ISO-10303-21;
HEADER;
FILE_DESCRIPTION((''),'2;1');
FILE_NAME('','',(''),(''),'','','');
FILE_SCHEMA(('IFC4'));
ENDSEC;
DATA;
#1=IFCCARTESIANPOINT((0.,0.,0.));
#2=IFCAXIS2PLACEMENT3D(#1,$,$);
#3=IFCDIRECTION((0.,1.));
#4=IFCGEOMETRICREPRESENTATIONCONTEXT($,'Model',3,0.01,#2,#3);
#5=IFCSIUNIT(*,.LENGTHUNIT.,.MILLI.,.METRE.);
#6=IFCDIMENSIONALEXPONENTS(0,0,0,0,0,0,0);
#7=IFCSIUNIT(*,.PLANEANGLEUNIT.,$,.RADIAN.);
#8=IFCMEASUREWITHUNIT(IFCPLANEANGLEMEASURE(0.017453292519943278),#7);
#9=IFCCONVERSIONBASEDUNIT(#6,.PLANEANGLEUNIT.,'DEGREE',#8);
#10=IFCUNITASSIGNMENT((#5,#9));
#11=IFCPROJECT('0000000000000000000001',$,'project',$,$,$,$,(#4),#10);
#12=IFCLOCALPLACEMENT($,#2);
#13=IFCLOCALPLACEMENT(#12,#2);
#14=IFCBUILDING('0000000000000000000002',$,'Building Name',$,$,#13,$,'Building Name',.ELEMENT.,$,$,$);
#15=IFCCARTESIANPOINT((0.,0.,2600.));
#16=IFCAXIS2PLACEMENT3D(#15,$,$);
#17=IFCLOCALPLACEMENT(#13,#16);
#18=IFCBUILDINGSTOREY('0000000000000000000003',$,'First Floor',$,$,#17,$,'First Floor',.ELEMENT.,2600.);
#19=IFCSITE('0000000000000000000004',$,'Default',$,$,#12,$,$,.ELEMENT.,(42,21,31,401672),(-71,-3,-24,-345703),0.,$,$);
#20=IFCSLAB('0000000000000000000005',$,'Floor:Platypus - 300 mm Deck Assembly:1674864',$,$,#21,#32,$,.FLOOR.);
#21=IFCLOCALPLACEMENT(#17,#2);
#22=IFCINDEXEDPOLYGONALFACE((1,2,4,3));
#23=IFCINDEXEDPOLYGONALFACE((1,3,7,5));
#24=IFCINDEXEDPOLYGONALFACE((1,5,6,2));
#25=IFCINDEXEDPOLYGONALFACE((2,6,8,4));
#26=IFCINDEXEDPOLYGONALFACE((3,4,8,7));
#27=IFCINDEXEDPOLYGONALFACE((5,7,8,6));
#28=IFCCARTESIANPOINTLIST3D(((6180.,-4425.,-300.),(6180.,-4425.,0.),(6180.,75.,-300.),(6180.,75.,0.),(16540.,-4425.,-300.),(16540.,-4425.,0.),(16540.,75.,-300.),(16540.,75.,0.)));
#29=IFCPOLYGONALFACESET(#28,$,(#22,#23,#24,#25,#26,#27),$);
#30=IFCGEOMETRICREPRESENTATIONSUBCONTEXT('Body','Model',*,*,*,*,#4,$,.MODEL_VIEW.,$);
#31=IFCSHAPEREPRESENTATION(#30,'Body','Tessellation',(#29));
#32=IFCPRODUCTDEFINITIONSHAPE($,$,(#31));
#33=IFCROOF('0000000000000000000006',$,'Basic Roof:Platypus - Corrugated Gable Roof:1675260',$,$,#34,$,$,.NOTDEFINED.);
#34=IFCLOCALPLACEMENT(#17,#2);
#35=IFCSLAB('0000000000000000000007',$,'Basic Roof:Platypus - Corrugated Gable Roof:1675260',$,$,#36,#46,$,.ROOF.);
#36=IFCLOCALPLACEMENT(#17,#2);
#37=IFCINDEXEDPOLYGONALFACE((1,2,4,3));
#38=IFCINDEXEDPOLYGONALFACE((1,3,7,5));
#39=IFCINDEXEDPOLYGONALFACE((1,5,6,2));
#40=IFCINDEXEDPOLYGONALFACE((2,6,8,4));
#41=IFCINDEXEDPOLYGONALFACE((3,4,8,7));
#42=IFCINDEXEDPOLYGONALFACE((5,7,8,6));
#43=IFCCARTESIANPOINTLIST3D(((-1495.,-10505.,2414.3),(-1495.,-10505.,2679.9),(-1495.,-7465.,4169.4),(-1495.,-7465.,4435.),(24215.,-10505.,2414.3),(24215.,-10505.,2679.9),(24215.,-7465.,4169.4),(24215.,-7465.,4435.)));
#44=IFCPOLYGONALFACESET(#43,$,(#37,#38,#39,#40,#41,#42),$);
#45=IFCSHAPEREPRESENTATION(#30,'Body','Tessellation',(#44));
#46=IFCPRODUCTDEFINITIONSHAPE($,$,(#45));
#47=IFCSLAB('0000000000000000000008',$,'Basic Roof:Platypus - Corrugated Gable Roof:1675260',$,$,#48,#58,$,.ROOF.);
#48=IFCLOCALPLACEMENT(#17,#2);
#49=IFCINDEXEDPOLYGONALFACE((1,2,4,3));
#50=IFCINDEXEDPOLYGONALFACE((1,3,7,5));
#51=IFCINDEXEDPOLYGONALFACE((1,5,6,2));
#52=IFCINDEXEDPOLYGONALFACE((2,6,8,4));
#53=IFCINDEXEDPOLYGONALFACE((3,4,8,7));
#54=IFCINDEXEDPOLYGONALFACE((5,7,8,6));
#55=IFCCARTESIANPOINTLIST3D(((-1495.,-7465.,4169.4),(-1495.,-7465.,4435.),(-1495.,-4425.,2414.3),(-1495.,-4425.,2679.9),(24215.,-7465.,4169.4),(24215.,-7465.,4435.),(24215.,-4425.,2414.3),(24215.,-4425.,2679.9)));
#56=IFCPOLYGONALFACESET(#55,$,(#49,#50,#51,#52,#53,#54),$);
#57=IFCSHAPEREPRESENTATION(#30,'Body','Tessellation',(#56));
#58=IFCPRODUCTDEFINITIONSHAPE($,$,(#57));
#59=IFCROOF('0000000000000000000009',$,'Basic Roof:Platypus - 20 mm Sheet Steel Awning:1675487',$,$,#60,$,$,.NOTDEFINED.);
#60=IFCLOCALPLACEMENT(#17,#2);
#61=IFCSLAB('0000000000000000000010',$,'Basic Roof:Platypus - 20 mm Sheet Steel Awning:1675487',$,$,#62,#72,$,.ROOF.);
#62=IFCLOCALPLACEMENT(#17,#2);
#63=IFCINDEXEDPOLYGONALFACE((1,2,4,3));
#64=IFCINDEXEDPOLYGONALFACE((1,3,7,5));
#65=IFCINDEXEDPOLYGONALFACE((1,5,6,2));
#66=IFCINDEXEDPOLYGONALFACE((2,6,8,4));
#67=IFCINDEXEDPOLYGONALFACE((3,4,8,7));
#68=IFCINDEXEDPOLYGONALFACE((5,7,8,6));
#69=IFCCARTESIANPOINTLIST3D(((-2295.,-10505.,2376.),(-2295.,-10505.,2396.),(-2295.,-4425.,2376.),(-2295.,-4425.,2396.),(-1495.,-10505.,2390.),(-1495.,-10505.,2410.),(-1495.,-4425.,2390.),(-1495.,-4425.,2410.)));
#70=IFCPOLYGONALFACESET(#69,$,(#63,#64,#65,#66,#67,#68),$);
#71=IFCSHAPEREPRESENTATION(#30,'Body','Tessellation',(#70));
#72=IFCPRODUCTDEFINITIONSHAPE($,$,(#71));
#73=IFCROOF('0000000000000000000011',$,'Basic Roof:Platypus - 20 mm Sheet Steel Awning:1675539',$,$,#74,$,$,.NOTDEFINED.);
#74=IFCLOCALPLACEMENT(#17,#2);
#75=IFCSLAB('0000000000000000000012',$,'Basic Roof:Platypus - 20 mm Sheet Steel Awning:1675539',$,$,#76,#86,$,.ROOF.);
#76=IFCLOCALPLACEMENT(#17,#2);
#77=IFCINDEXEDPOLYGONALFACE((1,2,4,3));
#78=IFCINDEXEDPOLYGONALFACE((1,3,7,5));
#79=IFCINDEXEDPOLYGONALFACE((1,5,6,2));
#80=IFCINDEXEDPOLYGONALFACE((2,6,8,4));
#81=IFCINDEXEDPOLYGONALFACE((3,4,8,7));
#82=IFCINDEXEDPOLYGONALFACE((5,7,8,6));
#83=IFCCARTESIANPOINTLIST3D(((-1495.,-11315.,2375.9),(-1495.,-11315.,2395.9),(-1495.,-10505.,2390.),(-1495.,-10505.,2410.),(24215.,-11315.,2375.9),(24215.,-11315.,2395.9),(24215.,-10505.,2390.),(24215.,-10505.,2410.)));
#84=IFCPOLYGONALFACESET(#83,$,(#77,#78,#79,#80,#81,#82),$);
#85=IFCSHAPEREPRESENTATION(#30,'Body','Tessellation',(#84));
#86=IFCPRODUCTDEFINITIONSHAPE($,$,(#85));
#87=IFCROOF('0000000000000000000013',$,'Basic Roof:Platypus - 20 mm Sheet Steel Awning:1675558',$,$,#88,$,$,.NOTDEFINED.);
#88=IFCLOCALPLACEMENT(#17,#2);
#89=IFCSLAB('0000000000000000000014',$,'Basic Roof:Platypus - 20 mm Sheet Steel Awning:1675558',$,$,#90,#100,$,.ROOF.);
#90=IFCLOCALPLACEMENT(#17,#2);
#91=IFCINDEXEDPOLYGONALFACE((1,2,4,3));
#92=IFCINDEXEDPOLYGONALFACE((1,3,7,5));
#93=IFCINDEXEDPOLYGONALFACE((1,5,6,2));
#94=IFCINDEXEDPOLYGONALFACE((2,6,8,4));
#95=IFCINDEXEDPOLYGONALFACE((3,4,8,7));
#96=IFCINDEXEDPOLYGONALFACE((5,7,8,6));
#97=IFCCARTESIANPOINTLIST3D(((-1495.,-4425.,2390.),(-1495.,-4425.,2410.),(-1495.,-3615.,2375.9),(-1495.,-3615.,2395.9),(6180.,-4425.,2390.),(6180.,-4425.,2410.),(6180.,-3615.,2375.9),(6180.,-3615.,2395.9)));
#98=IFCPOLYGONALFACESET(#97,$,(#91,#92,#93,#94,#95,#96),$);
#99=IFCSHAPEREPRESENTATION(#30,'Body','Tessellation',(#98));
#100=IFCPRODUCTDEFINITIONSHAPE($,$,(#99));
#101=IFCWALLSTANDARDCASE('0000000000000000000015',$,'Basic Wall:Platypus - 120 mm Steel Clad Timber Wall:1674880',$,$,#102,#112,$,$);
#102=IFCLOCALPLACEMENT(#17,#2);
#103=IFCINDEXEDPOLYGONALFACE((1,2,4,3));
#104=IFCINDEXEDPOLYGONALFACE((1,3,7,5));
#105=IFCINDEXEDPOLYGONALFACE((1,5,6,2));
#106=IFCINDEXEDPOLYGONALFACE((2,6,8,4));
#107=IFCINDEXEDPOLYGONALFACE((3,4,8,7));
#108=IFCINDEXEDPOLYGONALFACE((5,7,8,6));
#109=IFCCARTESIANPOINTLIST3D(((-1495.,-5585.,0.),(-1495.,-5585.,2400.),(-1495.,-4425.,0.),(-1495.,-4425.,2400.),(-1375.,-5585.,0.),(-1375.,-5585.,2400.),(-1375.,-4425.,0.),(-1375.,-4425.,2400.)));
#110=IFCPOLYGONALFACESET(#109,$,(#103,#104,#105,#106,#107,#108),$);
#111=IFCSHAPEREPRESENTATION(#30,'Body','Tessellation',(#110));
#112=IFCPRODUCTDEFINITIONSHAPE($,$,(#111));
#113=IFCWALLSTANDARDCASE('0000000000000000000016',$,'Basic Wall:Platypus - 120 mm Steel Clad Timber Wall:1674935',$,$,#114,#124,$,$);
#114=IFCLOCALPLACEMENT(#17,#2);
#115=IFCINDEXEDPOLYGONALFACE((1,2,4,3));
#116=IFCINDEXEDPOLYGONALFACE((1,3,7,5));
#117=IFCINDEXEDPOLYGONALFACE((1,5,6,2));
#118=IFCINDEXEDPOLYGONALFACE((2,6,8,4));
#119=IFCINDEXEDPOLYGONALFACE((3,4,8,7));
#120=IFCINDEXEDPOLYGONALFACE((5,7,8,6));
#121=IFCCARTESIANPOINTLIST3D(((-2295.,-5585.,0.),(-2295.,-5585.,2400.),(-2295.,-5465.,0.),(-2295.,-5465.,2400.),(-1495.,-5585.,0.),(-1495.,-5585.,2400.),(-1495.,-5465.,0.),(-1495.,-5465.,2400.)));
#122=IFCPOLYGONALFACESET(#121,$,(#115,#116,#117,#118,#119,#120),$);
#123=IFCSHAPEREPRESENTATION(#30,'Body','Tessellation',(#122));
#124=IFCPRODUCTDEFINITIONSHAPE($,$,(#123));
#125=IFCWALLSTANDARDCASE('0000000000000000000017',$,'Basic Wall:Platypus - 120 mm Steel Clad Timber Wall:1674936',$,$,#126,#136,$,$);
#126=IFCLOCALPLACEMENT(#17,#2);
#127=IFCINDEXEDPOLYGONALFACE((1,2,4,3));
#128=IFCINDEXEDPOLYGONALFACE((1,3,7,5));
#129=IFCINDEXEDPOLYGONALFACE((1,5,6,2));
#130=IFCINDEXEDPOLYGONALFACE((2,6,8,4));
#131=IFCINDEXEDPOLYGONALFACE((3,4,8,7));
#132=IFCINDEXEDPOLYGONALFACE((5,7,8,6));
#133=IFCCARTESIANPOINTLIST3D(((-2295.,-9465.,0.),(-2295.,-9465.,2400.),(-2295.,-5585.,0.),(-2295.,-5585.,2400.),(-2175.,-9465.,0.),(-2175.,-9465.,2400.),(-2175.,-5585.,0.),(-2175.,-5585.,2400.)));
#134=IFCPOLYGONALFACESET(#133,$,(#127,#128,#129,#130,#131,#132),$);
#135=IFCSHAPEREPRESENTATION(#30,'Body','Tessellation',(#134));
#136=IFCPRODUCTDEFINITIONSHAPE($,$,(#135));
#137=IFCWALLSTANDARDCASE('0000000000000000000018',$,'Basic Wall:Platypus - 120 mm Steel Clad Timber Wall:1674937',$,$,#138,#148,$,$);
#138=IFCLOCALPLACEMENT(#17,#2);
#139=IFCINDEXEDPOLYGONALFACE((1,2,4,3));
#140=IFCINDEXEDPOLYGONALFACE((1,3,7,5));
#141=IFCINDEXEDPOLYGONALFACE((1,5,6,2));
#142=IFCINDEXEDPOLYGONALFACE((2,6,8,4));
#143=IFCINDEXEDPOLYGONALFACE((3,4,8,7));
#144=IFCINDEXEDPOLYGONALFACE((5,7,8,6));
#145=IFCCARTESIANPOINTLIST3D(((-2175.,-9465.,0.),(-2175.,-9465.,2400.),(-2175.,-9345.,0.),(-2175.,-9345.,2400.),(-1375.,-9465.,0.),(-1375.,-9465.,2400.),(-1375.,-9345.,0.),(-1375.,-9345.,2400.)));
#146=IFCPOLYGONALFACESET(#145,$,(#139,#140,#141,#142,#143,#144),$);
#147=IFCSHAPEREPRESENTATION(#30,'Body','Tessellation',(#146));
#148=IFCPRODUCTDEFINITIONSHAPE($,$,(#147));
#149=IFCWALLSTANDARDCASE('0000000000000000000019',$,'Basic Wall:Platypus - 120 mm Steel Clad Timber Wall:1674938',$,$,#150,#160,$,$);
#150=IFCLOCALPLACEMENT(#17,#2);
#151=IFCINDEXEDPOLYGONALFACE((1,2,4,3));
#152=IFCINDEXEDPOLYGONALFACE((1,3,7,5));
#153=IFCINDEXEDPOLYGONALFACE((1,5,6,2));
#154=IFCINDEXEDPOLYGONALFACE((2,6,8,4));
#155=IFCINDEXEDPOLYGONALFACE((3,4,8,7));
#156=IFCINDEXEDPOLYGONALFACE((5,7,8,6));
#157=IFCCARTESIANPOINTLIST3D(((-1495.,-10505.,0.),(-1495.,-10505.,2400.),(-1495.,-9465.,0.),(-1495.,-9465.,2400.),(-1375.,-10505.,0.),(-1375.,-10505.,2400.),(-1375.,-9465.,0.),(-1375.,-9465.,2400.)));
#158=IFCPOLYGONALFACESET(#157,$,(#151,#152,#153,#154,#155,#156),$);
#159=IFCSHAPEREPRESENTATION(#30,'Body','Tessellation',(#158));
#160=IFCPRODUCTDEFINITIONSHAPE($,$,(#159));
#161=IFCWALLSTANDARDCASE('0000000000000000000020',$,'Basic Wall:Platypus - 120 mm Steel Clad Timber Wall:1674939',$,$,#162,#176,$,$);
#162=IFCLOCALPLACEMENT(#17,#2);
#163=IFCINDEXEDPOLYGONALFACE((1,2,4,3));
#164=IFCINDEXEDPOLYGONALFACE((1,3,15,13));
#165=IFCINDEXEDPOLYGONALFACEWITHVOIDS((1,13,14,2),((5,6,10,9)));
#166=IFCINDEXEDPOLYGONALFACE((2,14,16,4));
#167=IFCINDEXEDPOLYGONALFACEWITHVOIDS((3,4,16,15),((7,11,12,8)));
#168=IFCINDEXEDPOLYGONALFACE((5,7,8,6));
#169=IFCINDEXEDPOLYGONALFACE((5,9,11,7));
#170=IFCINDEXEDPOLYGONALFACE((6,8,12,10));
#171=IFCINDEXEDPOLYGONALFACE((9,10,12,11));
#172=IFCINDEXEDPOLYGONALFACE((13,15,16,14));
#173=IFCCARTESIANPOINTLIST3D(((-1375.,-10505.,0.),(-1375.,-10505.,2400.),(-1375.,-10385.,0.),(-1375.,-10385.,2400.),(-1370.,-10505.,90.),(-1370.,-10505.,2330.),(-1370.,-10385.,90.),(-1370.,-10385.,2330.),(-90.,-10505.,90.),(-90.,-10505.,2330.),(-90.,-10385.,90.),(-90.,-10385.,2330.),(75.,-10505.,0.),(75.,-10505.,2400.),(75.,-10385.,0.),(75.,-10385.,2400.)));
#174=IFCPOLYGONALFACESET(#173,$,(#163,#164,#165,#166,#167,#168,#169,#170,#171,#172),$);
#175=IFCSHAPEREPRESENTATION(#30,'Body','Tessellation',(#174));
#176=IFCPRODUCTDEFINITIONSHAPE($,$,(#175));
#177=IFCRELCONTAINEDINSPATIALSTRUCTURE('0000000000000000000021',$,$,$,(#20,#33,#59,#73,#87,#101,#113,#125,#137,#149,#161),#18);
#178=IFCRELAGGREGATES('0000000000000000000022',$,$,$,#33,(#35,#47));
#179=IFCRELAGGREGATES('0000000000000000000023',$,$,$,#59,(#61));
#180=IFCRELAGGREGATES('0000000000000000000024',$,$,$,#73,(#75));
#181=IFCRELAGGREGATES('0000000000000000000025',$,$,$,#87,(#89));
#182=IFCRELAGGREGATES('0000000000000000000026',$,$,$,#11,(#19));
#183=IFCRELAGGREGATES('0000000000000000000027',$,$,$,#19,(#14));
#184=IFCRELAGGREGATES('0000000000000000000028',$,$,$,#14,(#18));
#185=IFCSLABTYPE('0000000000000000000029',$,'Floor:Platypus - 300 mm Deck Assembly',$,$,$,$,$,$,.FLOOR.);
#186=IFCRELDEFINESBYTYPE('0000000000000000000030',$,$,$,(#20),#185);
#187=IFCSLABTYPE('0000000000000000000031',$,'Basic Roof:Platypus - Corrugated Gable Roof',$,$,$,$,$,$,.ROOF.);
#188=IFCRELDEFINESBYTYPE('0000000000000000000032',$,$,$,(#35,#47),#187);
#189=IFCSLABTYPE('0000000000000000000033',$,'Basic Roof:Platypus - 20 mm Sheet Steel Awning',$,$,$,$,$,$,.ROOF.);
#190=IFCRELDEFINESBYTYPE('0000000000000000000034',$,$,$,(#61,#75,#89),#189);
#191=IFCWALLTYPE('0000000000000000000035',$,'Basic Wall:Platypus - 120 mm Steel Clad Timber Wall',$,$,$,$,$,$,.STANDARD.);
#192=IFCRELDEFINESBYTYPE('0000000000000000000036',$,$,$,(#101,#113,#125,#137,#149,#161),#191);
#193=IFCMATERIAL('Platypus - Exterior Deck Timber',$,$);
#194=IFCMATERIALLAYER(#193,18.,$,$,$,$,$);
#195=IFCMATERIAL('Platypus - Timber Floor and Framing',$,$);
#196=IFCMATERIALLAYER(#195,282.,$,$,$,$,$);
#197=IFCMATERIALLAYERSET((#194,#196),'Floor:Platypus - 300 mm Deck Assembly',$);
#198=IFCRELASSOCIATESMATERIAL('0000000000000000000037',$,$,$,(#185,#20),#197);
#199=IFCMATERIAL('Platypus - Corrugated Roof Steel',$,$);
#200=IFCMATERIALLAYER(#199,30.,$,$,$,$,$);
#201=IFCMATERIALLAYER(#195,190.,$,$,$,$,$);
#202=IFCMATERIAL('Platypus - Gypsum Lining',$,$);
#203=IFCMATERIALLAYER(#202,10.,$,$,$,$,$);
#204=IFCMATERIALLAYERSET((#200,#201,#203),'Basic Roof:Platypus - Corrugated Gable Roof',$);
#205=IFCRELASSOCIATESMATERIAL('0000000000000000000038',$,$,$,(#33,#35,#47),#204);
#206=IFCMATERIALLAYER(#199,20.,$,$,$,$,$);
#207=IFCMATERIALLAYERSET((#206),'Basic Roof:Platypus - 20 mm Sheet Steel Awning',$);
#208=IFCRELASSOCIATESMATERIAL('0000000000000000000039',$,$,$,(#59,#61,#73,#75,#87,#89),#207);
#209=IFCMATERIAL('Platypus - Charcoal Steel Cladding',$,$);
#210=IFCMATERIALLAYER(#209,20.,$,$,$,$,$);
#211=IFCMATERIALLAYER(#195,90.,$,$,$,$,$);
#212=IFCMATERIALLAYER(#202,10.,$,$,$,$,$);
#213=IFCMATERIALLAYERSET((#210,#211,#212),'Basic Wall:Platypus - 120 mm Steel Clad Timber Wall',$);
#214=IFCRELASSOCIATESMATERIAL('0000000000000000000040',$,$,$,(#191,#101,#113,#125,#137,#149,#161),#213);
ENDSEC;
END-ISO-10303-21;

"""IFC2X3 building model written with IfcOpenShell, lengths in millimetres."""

from ifc_helpers import new_model, entity, si_unit, converted_unit, direction, frame, frame_2d, origin, origin_2d_with_axis, place, context, subcontext, project, spatial, rectangle, extrude, material, layer, layer_set, layer_usage, type_object, element, aggregate, save


model = new_model("IFC2X3")

# Units and contexts
model_context = context("Model", 3, precision=0.01, world=origin(), true_north=direction((0.0, 1.0)))
body_context = subcontext(model_context, "Body", "Model", "MODEL_VIEW")
ifc_project = project(units=[si_unit("LENGTHUNIT", "METRE", prefix="MILLI"), converted_unit("PLANEANGLEUNIT", "DEGREE", entity("IfcPlaneAngleMeasure", 0.017453292519943278), si_unit("PLANEANGLEUNIT", "RADIAN"), dimensions=[0, 0, 0, 0, 0, 0, 0])], contexts=[model_context])

# Site, building, storey
site_placement = place(None, origin())
site = spatial("IfcSite", under=ifc_project, at=site_placement, Name="Default", CompositionType="ELEMENT", RefLatitude=(42, 21, 31, 401672), RefLongitude=(-71, -3, -24, -345703), RefElevation=0.0)
building_placement = place(site_placement, origin())
building = spatial("IfcBuilding", under=site, at=building_placement, Name="Building Name", LongName="Building Name", CompositionType="ELEMENT")
storey_placement = place(building_placement, frame((0.0, 0.0, 2600.0)))
storey = spatial("IfcBuildingStorey", under=building, at=storey_placement, Name="First Floor", LongName="First Floor", CompositionType="ELEMENT", Elevation=2600.0)

# Slab
ifc_material_1 = material(Name="Platypus - Timber Floor and Framing")
ifc_material_2 = material(Name="Platypus - Exterior Deck Timber")
ifc_layer_1 = layer(ifc_material_2, 18.0)
ifc_layer_2 = layer(ifc_material_1, 282.0)
ifc_layer_set_1 = layer_set([ifc_layer_1, ifc_layer_2], Name="Floor:Platypus - 300 mm Deck Assembly")
ifc_layer_usage_1 = layer_usage(ifc_layer_set_1, "AXIS3", "POSITIVE", 0.0)
slab_type_1 = type_object("IfcSlabType", Name="Floor:Platypus - 300 mm Deck Assembly", PredefinedType="FLOOR", material=ifc_layer_set_1)
slab_1_placement = place(storey_placement, origin())
element("IfcSlab", 1, at=slab_1_placement, inside=storey, type_object=slab_type_1, material=ifc_layer_usage_1, Name="Floor:Platypus - 300 mm Deck Assembly:1674864", PredefinedType="FLOOR", context=body_context, shape_type="SweptSolid", body=[
    extrude(rectangle(XDim=4500.0, YDim=10360.0, at=origin_2d_with_axis()), frame((11360.0, -2175.0, 0.0), z_axis=(0.0, 0.0, -1.0), x_axis=(0.0, 1.0, 0.0)), (0.0, 0.0, 1.0), 300.0),
])

# Roof, slabs
ifc_material_3 = material(Name="Platypus - Corrugated Roof Steel")
ifc_layer_3 = layer(ifc_material_3, 30.0)
ifc_layer_4 = layer(ifc_material_1, 190.0)
ifc_material_4 = material(Name="Platypus - Gypsum Lining")
ifc_layer_5 = layer(ifc_material_4, 10.0)
ifc_layer_set_2 = layer_set([ifc_layer_3, ifc_layer_4, ifc_layer_5], Name="Basic Roof:Platypus - Corrugated Gable Roof")
roof_1_placement = place(storey_placement, frame((-1495.0, -10505.0, 2414.3)))
roof_1 = element("IfcRoof", 2, at=roof_1_placement, inside=storey, material=ifc_layer_set_2, Name="Basic Roof:Platypus - Corrugated Gable Roof:1675260", ShapeType="NOTDEFINED")
slab_type_2 = type_object("IfcSlabType", Name="Basic Roof:Platypus - Corrugated Gable Roof", PredefinedType="ROOF")
slab_2_placement = place(roof_1_placement, origin())
slab_2 = element("IfcSlab", 3, at=slab_2_placement, type_object=slab_type_2, material=ifc_layer_set_2, Name="Basic Roof:Platypus - Corrugated Gable Roof:1675260", PredefinedType="ROOF", context=body_context, shape_type="SweptSolid", body=[
    extrude(rectangle(XDim=25710.0, YDim=3510.3, at=frame_2d((0.0, 0.0), x_axis=(-1.0, 0.0))), frame((12855.0, 1520.0, 877.6), z_axis=(0.0, -0.5, 0.866025), x_axis=(1.0, 0.0, 0.0)), (0.0, 0.5, 0.866025), 265.6),
])
slab_3_placement = place(roof_1_placement, origin())
slab_3 = element("IfcSlab", 4, at=slab_3_placement, type_object=slab_type_2, material=ifc_layer_set_2, Name="Basic Roof:Platypus - Corrugated Gable Roof:1675260", PredefinedType="ROOF", context=body_context, shape_type="SweptSolid", body=[
    extrude(rectangle(XDim=3510.3, YDim=25710.0, at=frame_2d((0.0, 0.0), x_axis=(0.0, -1.0))), frame((12855.0, 4560.0, 877.6), z_axis=(0.0, 0.5, 0.866025), x_axis=(1.0, 0.0, 0.0)), (0.0, -0.5, 0.866025), 265.6),
])
aggregate(roof_1, [slab_2, slab_3])

# Roofs, slabs
ifc_layer_6 = layer(ifc_material_3, 20.0)
ifc_layer_set_3 = layer_set([ifc_layer_6], Name="Basic Roof:Platypus - 20 mm Sheet Steel Awning")
roof_2_placement = place(storey_placement, frame((-2295.0, -10505.0, 2376.0)))
roof_2 = element("IfcRoof", 5, at=roof_2_placement, inside=storey, material=ifc_layer_set_3, Name="Basic Roof:Platypus - 20 mm Sheet Steel Awning:1675487", ShapeType="NOTDEFINED")
slab_type_3 = type_object("IfcSlabType", Name="Basic Roof:Platypus - 20 mm Sheet Steel Awning", PredefinedType="ROOF")
slab_4_placement = place(roof_2_placement, origin())
slab_4 = element("IfcSlab", 6, at=slab_4_placement, type_object=slab_type_3, material=ifc_layer_set_3, Name="Basic Roof:Platypus - 20 mm Sheet Steel Awning:1675487", PredefinedType="ROOF", context=body_context, shape_type="SweptSolid", body=[
    extrude(rectangle(XDim=800.1, YDim=6080.0, at=frame_2d((0.0, 0.0), x_axis=(-1.0, 0.0))), frame((400.0, 3040.0, 7.0), z_axis=(-0.017451, 0.0, 0.999848), x_axis=(0.999848, 0.0, 0.017451)), (0.017451, 0.0, 0.999848), 20.0),
])
aggregate(roof_2, [slab_4])
roof_3_placement = place(storey_placement, frame((-1495.0, -11315.0, 2375.9)))
roof_3 = element("IfcRoof", 7, at=roof_3_placement, inside=storey, material=ifc_layer_set_3, Name="Basic Roof:Platypus - 20 mm Sheet Steel Awning:1675539", ShapeType="NOTDEFINED")
slab_5_placement = place(roof_3_placement, origin())
slab_5 = element("IfcSlab", 8, at=slab_5_placement, type_object=slab_type_3, material=ifc_layer_set_3, Name="Basic Roof:Platypus - 20 mm Sheet Steel Awning:1675539", PredefinedType="ROOF", context=body_context, shape_type="SweptSolid", body=[
    extrude(rectangle(XDim=25710.0, YDim=810.1, at=frame_2d((0.0, 0.0), x_axis=(-1.0, 0.0))), frame((12855.0, 405.0, 7.1), z_axis=(0.0, -0.017451, 0.999848), x_axis=(1.0, 0.0, 0.0)), (0.0, 0.017451, 0.999848), 20.0),
])
aggregate(roof_3, [slab_5])
roof_4_placement = place(storey_placement, frame((-1495.0, -4425.0, 2375.9)))
roof_4 = element("IfcRoof", 9, at=roof_4_placement, inside=storey, material=ifc_layer_set_3, Name="Basic Roof:Platypus - 20 mm Sheet Steel Awning:1675558", ShapeType="NOTDEFINED")
slab_6_placement = place(roof_4_placement, origin())
slab_6 = element("IfcSlab", 10, at=slab_6_placement, type_object=slab_type_3, material=ifc_layer_set_3, Name="Basic Roof:Platypus - 20 mm Sheet Steel Awning:1675558", PredefinedType="ROOF", context=body_context, shape_type="SweptSolid", body=[
    extrude(rectangle(XDim=810.1, YDim=7675.0, at=frame_2d((0.0, 0.0), x_axis=(0.0, 1.0))), frame((3837.5, 405.0, 7.1), z_axis=(0.0, 0.017451, 0.999848), x_axis=(1.0, 0.0, 0.0)), (0.0, -0.017451, 0.999848), 20.0),
])
aggregate(roof_4, [slab_6])

# Walls
ifc_material_5 = material(Name="Platypus - Charcoal Steel Cladding")
ifc_layer_7 = layer(ifc_material_5, 20.0)
ifc_layer_8 = layer(ifc_material_1, 90.0)
ifc_layer_9 = layer(ifc_material_4, 10.0)
ifc_layer_set_4 = layer_set([ifc_layer_7, ifc_layer_8, ifc_layer_9], Name="Basic Wall:Platypus - 120 mm Steel Clad Timber Wall")
ifc_layer_usage_2 = layer_usage(ifc_layer_set_4, "AXIS2", "POSITIVE", -60.0)
wall_type_1 = type_object("IfcWallType", Name="Basic Wall:Platypus - 120 mm Steel Clad Timber Wall", PredefinedType="STANDARD", material=ifc_layer_set_4)
wall_1_placement = place(storey_placement, frame((-1435.0, -4425.0, 0.0), z_axis=(0.0, 0.0, 1.0), x_axis=(0.0, -1.0, 0.0)))
element("IfcWallStandardCase", 11, at=wall_1_placement, inside=storey, type_object=wall_type_1, material=ifc_layer_usage_2, Name="Basic Wall:Platypus - 120 mm Steel Clad Timber Wall:1674880", context=body_context, shape_type="SweptSolid", body=[
    extrude(rectangle(XDim=1160.0, YDim=120.0, at=frame_2d((580.0, 0.0), x_axis=(-1.0, 0.0))), origin(), (0.0, 0.0, 1.0), 2400.0),
])
ifc_layer_usage_3 = layer_usage(ifc_layer_set_4, "AXIS2", "POSITIVE", -60.0)
wall_2_placement = place(storey_placement, frame((-1495.0, -5525.0, 0.0), z_axis=(0.0, 0.0, 1.0), x_axis=(-1.0, 0.0, 0.0)))
element("IfcWallStandardCase", 12, at=wall_2_placement, inside=storey, type_object=wall_type_1, material=ifc_layer_usage_3, Name="Basic Wall:Platypus - 120 mm Steel Clad Timber Wall:1674935", context=body_context, shape_type="SweptSolid", body=[
    extrude(rectangle(XDim=800.0, YDim=120.0, at=frame_2d((400.0, 0.0), x_axis=(-1.0, 0.0))), origin(), (0.0, 0.0, 1.0), 2400.0),
])
ifc_layer_usage_4 = layer_usage(ifc_layer_set_4, "AXIS2", "POSITIVE", -60.0)
wall_3_placement = place(storey_placement, frame((-2235.0, -5585.0, 0.0), z_axis=(0.0, 0.0, 1.0), x_axis=(0.0, -1.0, 0.0)))
element("IfcWallStandardCase", 13, at=wall_3_placement, inside=storey, type_object=wall_type_1, material=ifc_layer_usage_4, Name="Basic Wall:Platypus - 120 mm Steel Clad Timber Wall:1674936", context=body_context, shape_type="SweptSolid", body=[
    extrude(rectangle(XDim=3880.0, YDim=120.0, at=frame_2d((1940.0, 0.0), x_axis=(-1.0, 0.0))), origin(), (0.0, 0.0, 1.0), 2400.0),
])
ifc_layer_usage_5 = layer_usage(ifc_layer_set_4, "AXIS2", "POSITIVE", -60.0)
wall_4_placement = place(storey_placement, frame((-2175.0, -9405.0, 0.0)))
element("IfcWallStandardCase", 14, at=wall_4_placement, inside=storey, type_object=wall_type_1, material=ifc_layer_usage_5, Name="Basic Wall:Platypus - 120 mm Steel Clad Timber Wall:1674937", context=body_context, shape_type="SweptSolid", body=[
    extrude(rectangle(XDim=800.0, YDim=120.0, at=frame_2d((400.0, 0.0), x_axis=(-1.0, 0.0))), origin(), (0.0, 0.0, 1.0), 2400.0),
])
ifc_layer_usage_6 = layer_usage(ifc_layer_set_4, "AXIS2", "POSITIVE", -60.0)
wall_5_placement = place(storey_placement, frame((-1435.0, -9465.0, 0.0), z_axis=(0.0, 0.0, 1.0), x_axis=(0.0, -1.0, 0.0)))
element("IfcWallStandardCase", 15, at=wall_5_placement, inside=storey, type_object=wall_type_1, material=ifc_layer_usage_6, Name="Basic Wall:Platypus - 120 mm Steel Clad Timber Wall:1674938", context=body_context, shape_type="SweptSolid", body=[
    extrude(rectangle(XDim=1040.0, YDim=120.0, at=frame_2d((520.0, 0.0), x_axis=(-1.0, 0.0))), origin(), (0.0, 0.0, 1.0), 2400.0),
])

# Wall, opening
ifc_layer_usage_7 = layer_usage(ifc_layer_set_4, "AXIS2", "POSITIVE", -60.0)
wall_6_placement = place(storey_placement, frame((-1375.0, -10445.0, 0.0)))
wall_6 = element("IfcWallStandardCase", 16, at=wall_6_placement, inside=storey, type_object=wall_type_1, material=ifc_layer_usage_7, Name="Basic Wall:Platypus - 120 mm Steel Clad Timber Wall:1674939", context=body_context, shape_type="SweptSolid", body=[
    extrude(rectangle(XDim=1450.0, YDim=120.0, at=frame_2d((725.0, 0.0), x_axis=(-1.0, 0.0))), origin(), (0.0, 0.0, 1.0), 2400.0),
])
opening_1_placement = place(wall_6_placement, frame((5.0, -60.0, 90.0)))
element("IfcOpeningElement", 17, at=opening_1_placement, cuts=wall_6, ObjectType="Opening", context=body_context, shape_type="SweptSolid", body=[
    extrude(rectangle(XDim=2240.0, YDim=1280.0, at=frame_2d((1120.0, 640.0), x_axis=(-1.0, 0.0))), frame((0.0, 0.0, 0.0), z_axis=(0.0, 1.0, 0.0), x_axis=(0.0, 0.0, 1.0)), (0.0, 0.0, 1.0), 120.0),
])

save(model, "model.ifc")
